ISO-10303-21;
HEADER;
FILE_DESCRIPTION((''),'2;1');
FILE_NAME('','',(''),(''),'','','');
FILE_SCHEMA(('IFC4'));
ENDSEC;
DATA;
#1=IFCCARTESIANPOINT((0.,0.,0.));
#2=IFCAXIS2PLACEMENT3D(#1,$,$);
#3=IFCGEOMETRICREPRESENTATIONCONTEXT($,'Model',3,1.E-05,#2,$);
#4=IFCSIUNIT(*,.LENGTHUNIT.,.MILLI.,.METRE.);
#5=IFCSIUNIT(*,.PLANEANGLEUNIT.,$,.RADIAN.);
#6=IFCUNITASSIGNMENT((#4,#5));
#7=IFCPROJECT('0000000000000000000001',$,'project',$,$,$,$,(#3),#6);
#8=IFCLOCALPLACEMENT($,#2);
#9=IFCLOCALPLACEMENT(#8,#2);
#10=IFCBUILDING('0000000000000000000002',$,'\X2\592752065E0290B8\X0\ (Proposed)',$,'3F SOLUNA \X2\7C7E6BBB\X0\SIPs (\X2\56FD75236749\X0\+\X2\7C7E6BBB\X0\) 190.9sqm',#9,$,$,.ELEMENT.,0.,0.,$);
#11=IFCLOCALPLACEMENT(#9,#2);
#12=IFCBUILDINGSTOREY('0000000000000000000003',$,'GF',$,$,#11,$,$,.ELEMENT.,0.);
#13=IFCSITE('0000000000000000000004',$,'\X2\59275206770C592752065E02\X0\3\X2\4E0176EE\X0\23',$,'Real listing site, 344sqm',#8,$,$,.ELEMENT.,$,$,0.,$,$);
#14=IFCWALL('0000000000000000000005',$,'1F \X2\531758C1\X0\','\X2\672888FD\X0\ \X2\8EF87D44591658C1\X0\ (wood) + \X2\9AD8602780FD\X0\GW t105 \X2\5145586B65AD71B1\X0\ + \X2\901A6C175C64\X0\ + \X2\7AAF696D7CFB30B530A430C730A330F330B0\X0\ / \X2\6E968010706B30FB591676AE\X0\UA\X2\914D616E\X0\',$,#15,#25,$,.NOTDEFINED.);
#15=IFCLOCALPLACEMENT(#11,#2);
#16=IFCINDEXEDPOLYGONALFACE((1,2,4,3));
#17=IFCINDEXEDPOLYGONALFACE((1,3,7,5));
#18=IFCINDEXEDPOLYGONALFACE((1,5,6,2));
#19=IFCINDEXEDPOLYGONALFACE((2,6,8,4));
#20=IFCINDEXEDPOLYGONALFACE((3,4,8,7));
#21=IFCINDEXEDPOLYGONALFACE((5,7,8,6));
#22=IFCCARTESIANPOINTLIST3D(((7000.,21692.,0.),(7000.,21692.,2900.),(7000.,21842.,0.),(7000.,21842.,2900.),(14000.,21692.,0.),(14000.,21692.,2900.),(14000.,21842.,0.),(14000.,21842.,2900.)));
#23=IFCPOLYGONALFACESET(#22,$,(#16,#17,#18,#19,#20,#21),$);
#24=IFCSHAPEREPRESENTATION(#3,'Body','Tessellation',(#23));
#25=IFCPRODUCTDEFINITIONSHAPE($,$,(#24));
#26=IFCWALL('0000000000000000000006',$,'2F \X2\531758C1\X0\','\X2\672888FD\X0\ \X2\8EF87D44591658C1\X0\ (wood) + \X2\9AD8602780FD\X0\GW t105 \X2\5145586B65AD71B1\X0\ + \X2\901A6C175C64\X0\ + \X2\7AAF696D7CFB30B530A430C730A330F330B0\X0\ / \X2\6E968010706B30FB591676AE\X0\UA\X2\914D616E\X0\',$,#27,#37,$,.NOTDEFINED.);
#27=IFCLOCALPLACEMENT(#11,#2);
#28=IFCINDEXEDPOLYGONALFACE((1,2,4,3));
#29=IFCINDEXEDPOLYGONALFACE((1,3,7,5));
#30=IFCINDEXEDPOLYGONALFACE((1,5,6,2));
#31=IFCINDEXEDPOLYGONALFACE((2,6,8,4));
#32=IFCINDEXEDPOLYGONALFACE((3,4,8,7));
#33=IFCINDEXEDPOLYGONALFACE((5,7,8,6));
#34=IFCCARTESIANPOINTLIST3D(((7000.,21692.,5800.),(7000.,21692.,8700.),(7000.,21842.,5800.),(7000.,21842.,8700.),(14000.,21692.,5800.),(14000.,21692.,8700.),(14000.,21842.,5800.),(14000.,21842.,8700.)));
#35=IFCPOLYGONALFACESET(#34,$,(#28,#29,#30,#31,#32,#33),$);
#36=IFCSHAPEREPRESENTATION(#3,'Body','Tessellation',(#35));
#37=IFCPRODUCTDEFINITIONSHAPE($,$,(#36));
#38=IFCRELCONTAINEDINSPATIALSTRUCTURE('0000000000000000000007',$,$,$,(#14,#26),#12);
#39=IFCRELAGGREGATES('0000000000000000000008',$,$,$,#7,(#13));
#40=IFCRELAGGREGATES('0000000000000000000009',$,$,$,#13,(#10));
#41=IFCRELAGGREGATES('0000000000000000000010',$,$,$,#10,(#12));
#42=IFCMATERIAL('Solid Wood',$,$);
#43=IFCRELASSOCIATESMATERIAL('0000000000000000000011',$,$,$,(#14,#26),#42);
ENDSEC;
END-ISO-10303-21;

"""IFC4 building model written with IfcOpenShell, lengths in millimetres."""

from ifc_helpers import new_model, si_unit, frame, frame_2d, origin, place, context, project, spatial, rectangle, extrude, material, element, save


model = new_model("IFC4")

# Units and contexts
model_context = context("Model", 3, precision=1e-05, world=origin())
ifc_project = project(units=[si_unit("LENGTHUNIT", "METRE", prefix="MILLI"), si_unit("PLANEANGLEUNIT", "RADIAN")], contexts=[model_context])

# Site, building, storey
site_placement = place(None, origin())
site = spatial("IfcSite", under=ifc_project, at=site_placement, Name="大分県大分市3丁目23", ObjectType="Real listing site, 344sqm", CompositionType="ELEMENT", RefElevation=0.0)
building_placement = place(site_placement, origin())
building = spatial("IfcBuilding", under=site, at=building_placement, Name="大分市邸 (Proposed)", ObjectType="3F SOLUNA 籾殻SIPs (国産杉+籾殻) 190.9sqm", CompositionType="ELEMENT", ElevationOfRefHeight=0.0, ElevationOfTerrain=0.0)
storey_placement = place(building_placement, origin())
storey = spatial("IfcBuildingStorey", under=building, at=storey_placement, Name="GF", CompositionType="ELEMENT", Elevation=0.0)

# Shared definitions
ifc_material_1 = material(Name="Solid Wood")

# Wall
wall_1_placement = place(storey_placement, frame((3500.0, 10846.0, 0.0)))
element("IfcWall", 1, at=wall_1_placement, inside=storey, material=ifc_material_1, Name="1F 北壁", Description="木製 軸組外壁 (wood) + 高性能GW t105 充填断熱 + 通気層 + 窯業系サイディング / 準耐火・外皮UA配慮", PredefinedType="NOTDEFINED", context=model_context, shape_type="SweptSolid", body=[
    extrude(rectangle(XDim=7000.0, YDim=150.0, at=frame_2d((3500.0, 75.0))), frame((3500.0, 10846.0, 0.0)), (0.0, 0.0, 1.0), 2900.0),
])

# Wall
wall_2_placement = place(storey_placement, frame((3500.0, 10846.0, 2900.0)))
element("IfcWall", 2, at=wall_2_placement, inside=storey, material=ifc_material_1, Name="2F 北壁", Description="木製 軸組外壁 (wood) + 高性能GW t105 充填断熱 + 通気層 + 窯業系サイディング / 準耐火・外皮UA配慮", PredefinedType="NOTDEFINED", context=model_context, shape_type="SweptSolid", body=[
    extrude(rectangle(XDim=7000.0, YDim=150.0, at=frame_2d((3500.0, 75.0))), frame((3500.0, 10846.0, 2900.0)), (0.0, 0.0, 1.0), 2900.0),
])

save(model, "model.ifc")
